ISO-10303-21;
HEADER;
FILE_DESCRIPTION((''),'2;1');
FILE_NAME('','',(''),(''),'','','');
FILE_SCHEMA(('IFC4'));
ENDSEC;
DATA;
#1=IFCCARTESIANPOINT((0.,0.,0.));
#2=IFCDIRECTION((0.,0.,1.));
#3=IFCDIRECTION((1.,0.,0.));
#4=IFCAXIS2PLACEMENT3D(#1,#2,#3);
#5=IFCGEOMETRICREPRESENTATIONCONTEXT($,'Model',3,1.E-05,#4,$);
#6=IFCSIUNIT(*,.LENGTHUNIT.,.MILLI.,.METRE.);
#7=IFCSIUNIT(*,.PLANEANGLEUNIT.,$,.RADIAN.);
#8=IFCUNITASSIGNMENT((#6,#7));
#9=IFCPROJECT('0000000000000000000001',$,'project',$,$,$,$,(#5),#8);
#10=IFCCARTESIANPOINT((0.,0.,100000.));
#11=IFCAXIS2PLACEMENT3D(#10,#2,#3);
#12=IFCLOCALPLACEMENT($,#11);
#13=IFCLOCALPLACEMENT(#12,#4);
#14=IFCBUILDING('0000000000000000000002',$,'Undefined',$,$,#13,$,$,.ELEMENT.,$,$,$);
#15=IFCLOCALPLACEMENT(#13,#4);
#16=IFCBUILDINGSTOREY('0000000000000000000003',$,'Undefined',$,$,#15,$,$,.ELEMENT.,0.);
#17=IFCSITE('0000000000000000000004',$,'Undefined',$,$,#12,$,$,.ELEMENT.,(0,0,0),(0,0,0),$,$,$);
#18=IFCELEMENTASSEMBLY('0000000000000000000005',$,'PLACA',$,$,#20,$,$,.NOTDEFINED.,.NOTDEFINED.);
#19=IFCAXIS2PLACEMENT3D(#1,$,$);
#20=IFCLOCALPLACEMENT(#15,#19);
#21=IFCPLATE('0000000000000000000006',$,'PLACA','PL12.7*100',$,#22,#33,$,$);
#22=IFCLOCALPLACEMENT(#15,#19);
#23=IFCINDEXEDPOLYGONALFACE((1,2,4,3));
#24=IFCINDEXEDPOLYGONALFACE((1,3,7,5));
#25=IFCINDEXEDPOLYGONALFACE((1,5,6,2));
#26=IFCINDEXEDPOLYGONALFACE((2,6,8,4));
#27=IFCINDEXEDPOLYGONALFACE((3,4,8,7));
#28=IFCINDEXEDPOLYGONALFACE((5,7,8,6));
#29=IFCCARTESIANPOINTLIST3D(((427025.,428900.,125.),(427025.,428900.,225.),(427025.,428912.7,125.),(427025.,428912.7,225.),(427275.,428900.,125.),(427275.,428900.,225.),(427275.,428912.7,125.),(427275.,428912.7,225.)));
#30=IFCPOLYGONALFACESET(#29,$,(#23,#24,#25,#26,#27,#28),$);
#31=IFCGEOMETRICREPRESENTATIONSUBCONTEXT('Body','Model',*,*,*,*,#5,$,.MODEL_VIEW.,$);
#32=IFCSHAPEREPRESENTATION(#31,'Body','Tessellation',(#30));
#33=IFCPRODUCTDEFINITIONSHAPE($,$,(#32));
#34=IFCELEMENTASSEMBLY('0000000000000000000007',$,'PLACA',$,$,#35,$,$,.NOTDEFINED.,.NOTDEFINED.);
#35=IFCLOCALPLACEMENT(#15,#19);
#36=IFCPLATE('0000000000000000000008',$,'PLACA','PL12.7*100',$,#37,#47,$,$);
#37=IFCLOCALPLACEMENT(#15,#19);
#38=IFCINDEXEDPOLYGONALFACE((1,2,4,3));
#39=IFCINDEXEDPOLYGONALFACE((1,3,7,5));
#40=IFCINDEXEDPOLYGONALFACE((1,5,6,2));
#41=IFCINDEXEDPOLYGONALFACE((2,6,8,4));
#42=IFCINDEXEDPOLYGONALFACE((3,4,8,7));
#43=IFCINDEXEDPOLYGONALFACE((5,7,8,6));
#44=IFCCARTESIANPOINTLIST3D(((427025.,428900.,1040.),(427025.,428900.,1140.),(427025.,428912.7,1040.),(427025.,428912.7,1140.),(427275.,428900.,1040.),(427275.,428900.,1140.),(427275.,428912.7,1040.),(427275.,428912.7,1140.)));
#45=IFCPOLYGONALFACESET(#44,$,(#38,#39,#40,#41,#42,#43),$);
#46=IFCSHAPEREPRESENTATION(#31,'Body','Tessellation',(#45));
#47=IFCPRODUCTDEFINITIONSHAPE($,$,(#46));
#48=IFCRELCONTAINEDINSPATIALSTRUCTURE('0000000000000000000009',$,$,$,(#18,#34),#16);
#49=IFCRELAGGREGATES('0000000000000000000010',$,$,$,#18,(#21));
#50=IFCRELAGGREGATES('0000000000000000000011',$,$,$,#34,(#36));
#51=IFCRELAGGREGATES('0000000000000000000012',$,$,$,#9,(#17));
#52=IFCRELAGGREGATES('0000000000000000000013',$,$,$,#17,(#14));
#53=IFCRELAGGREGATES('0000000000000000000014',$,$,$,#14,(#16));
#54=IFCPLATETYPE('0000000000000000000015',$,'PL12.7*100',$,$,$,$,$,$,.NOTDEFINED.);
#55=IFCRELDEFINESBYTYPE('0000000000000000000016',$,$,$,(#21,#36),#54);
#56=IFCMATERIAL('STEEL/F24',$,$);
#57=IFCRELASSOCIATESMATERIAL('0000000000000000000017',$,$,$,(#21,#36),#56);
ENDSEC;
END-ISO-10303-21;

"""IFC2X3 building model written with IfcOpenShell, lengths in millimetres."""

from ifc_helpers import new_model, si_unit, frame, origin_with_axes, place, context, subcontext, project, spatial, polyline, outline, extrude, material, type_object, element, aggregate, save


model = new_model("IFC2X3")

# Units and contexts
model_context = context("Model", 3, precision=1e-05, world=origin_with_axes())
body_context = subcontext(model_context, "Body", "Model", "MODEL_VIEW")
ifc_project = project(units=[si_unit("LENGTHUNIT", "METRE", prefix="MILLI"), si_unit("PLANEANGLEUNIT", "RADIAN")], contexts=[model_context])

# Site, building, storey
site_placement = place(None, frame((0.0, 0.0, 100000.0), z_axis=(0.0, 0.0, 1.0), x_axis=(1.0, 0.0, 0.0)))
site = spatial("IfcSite", under=ifc_project, at=site_placement, Name="Undefined", CompositionType="ELEMENT", RefLatitude=(0, 0, 0), RefLongitude=(0, 0, 0))
building_placement = place(site_placement, origin_with_axes())
building = spatial("IfcBuilding", under=site, at=building_placement, Name="Undefined", CompositionType="ELEMENT")
storey_placement = place(building_placement, origin_with_axes())
storey = spatial("IfcBuildingStorey", under=building, at=storey_placement, Name="Undefined", CompositionType="ELEMENT", Elevation=0.0)

# Element assemblies, plates
ifc_material_1 = material(Name="STEEL/F24")
plate_type = type_object("IfcPlateType", Name="PL12.7*100", PredefinedType="NOTDEFINED")
assembly_1_placement = place(storey_placement, origin_with_axes())
assembly_1 = element("IfcElementAssembly", 1, at=assembly_1_placement, inside=storey, Name="PLACA", AssemblyPlace="NOTDEFINED", PredefinedType="NOTDEFINED")
plate_1_placement = place(assembly_1_placement, frame((427275.0, 428906.4, 225.0), z_axis=(0.0, -1.0, 0.0), x_axis=(-1.0, 0.0, 0.0)))
plate_1 = element("IfcPlate", 2, at=plate_1_placement, type_object=plate_type, material=ifc_material_1, Name="PLACA", Description="PL12.7*100", context=body_context, shape_type="SweptSolid", body=[
    extrude(outline(polyline([(0.0, 0.0), (250.0, 0.0), (250.0, 100.0), (0.0, 100.0), (0.0, 0.0)])), frame((0.0, 0.0, -6.3), z_axis=(0.0, 0.0, 1.0), x_axis=(1.0, 0.0, 0.0)), (0.0, 0.0, 1.0), 12.7),
])
aggregate(assembly_1, [plate_1])
assembly_2_placement = place(storey_placement, origin_with_axes())
assembly_2 = element("IfcElementAssembly", 3, at=assembly_2_placement, inside=storey, Name="PLACA", AssemblyPlace="NOTDEFINED", PredefinedType="NOTDEFINED")
plate_2_placement = place(assembly_2_placement, frame((427275.0, 428906.4, 1140.0), z_axis=(0.0, -1.0, 0.0), x_axis=(-1.0, 0.0, 0.0)))
plate_2 = element("IfcPlate", 4, at=plate_2_placement, type_object=plate_type, material=ifc_material_1, Name="PLACA", Description="PL12.7*100", context=body_context, shape_type="SweptSolid", body=[
    extrude(outline(polyline([(0.0, 0.0), (250.0, 0.0), (250.0, 100.0), (0.0, 100.0), (0.0, 0.0)])), frame((0.0, 0.0, -6.3), z_axis=(0.0, 0.0, 1.0), x_axis=(1.0, 0.0, 0.0)), (0.0, 0.0, 1.0), 12.7),
])
aggregate(assembly_2, [plate_2])

save(model, "model.ifc")
